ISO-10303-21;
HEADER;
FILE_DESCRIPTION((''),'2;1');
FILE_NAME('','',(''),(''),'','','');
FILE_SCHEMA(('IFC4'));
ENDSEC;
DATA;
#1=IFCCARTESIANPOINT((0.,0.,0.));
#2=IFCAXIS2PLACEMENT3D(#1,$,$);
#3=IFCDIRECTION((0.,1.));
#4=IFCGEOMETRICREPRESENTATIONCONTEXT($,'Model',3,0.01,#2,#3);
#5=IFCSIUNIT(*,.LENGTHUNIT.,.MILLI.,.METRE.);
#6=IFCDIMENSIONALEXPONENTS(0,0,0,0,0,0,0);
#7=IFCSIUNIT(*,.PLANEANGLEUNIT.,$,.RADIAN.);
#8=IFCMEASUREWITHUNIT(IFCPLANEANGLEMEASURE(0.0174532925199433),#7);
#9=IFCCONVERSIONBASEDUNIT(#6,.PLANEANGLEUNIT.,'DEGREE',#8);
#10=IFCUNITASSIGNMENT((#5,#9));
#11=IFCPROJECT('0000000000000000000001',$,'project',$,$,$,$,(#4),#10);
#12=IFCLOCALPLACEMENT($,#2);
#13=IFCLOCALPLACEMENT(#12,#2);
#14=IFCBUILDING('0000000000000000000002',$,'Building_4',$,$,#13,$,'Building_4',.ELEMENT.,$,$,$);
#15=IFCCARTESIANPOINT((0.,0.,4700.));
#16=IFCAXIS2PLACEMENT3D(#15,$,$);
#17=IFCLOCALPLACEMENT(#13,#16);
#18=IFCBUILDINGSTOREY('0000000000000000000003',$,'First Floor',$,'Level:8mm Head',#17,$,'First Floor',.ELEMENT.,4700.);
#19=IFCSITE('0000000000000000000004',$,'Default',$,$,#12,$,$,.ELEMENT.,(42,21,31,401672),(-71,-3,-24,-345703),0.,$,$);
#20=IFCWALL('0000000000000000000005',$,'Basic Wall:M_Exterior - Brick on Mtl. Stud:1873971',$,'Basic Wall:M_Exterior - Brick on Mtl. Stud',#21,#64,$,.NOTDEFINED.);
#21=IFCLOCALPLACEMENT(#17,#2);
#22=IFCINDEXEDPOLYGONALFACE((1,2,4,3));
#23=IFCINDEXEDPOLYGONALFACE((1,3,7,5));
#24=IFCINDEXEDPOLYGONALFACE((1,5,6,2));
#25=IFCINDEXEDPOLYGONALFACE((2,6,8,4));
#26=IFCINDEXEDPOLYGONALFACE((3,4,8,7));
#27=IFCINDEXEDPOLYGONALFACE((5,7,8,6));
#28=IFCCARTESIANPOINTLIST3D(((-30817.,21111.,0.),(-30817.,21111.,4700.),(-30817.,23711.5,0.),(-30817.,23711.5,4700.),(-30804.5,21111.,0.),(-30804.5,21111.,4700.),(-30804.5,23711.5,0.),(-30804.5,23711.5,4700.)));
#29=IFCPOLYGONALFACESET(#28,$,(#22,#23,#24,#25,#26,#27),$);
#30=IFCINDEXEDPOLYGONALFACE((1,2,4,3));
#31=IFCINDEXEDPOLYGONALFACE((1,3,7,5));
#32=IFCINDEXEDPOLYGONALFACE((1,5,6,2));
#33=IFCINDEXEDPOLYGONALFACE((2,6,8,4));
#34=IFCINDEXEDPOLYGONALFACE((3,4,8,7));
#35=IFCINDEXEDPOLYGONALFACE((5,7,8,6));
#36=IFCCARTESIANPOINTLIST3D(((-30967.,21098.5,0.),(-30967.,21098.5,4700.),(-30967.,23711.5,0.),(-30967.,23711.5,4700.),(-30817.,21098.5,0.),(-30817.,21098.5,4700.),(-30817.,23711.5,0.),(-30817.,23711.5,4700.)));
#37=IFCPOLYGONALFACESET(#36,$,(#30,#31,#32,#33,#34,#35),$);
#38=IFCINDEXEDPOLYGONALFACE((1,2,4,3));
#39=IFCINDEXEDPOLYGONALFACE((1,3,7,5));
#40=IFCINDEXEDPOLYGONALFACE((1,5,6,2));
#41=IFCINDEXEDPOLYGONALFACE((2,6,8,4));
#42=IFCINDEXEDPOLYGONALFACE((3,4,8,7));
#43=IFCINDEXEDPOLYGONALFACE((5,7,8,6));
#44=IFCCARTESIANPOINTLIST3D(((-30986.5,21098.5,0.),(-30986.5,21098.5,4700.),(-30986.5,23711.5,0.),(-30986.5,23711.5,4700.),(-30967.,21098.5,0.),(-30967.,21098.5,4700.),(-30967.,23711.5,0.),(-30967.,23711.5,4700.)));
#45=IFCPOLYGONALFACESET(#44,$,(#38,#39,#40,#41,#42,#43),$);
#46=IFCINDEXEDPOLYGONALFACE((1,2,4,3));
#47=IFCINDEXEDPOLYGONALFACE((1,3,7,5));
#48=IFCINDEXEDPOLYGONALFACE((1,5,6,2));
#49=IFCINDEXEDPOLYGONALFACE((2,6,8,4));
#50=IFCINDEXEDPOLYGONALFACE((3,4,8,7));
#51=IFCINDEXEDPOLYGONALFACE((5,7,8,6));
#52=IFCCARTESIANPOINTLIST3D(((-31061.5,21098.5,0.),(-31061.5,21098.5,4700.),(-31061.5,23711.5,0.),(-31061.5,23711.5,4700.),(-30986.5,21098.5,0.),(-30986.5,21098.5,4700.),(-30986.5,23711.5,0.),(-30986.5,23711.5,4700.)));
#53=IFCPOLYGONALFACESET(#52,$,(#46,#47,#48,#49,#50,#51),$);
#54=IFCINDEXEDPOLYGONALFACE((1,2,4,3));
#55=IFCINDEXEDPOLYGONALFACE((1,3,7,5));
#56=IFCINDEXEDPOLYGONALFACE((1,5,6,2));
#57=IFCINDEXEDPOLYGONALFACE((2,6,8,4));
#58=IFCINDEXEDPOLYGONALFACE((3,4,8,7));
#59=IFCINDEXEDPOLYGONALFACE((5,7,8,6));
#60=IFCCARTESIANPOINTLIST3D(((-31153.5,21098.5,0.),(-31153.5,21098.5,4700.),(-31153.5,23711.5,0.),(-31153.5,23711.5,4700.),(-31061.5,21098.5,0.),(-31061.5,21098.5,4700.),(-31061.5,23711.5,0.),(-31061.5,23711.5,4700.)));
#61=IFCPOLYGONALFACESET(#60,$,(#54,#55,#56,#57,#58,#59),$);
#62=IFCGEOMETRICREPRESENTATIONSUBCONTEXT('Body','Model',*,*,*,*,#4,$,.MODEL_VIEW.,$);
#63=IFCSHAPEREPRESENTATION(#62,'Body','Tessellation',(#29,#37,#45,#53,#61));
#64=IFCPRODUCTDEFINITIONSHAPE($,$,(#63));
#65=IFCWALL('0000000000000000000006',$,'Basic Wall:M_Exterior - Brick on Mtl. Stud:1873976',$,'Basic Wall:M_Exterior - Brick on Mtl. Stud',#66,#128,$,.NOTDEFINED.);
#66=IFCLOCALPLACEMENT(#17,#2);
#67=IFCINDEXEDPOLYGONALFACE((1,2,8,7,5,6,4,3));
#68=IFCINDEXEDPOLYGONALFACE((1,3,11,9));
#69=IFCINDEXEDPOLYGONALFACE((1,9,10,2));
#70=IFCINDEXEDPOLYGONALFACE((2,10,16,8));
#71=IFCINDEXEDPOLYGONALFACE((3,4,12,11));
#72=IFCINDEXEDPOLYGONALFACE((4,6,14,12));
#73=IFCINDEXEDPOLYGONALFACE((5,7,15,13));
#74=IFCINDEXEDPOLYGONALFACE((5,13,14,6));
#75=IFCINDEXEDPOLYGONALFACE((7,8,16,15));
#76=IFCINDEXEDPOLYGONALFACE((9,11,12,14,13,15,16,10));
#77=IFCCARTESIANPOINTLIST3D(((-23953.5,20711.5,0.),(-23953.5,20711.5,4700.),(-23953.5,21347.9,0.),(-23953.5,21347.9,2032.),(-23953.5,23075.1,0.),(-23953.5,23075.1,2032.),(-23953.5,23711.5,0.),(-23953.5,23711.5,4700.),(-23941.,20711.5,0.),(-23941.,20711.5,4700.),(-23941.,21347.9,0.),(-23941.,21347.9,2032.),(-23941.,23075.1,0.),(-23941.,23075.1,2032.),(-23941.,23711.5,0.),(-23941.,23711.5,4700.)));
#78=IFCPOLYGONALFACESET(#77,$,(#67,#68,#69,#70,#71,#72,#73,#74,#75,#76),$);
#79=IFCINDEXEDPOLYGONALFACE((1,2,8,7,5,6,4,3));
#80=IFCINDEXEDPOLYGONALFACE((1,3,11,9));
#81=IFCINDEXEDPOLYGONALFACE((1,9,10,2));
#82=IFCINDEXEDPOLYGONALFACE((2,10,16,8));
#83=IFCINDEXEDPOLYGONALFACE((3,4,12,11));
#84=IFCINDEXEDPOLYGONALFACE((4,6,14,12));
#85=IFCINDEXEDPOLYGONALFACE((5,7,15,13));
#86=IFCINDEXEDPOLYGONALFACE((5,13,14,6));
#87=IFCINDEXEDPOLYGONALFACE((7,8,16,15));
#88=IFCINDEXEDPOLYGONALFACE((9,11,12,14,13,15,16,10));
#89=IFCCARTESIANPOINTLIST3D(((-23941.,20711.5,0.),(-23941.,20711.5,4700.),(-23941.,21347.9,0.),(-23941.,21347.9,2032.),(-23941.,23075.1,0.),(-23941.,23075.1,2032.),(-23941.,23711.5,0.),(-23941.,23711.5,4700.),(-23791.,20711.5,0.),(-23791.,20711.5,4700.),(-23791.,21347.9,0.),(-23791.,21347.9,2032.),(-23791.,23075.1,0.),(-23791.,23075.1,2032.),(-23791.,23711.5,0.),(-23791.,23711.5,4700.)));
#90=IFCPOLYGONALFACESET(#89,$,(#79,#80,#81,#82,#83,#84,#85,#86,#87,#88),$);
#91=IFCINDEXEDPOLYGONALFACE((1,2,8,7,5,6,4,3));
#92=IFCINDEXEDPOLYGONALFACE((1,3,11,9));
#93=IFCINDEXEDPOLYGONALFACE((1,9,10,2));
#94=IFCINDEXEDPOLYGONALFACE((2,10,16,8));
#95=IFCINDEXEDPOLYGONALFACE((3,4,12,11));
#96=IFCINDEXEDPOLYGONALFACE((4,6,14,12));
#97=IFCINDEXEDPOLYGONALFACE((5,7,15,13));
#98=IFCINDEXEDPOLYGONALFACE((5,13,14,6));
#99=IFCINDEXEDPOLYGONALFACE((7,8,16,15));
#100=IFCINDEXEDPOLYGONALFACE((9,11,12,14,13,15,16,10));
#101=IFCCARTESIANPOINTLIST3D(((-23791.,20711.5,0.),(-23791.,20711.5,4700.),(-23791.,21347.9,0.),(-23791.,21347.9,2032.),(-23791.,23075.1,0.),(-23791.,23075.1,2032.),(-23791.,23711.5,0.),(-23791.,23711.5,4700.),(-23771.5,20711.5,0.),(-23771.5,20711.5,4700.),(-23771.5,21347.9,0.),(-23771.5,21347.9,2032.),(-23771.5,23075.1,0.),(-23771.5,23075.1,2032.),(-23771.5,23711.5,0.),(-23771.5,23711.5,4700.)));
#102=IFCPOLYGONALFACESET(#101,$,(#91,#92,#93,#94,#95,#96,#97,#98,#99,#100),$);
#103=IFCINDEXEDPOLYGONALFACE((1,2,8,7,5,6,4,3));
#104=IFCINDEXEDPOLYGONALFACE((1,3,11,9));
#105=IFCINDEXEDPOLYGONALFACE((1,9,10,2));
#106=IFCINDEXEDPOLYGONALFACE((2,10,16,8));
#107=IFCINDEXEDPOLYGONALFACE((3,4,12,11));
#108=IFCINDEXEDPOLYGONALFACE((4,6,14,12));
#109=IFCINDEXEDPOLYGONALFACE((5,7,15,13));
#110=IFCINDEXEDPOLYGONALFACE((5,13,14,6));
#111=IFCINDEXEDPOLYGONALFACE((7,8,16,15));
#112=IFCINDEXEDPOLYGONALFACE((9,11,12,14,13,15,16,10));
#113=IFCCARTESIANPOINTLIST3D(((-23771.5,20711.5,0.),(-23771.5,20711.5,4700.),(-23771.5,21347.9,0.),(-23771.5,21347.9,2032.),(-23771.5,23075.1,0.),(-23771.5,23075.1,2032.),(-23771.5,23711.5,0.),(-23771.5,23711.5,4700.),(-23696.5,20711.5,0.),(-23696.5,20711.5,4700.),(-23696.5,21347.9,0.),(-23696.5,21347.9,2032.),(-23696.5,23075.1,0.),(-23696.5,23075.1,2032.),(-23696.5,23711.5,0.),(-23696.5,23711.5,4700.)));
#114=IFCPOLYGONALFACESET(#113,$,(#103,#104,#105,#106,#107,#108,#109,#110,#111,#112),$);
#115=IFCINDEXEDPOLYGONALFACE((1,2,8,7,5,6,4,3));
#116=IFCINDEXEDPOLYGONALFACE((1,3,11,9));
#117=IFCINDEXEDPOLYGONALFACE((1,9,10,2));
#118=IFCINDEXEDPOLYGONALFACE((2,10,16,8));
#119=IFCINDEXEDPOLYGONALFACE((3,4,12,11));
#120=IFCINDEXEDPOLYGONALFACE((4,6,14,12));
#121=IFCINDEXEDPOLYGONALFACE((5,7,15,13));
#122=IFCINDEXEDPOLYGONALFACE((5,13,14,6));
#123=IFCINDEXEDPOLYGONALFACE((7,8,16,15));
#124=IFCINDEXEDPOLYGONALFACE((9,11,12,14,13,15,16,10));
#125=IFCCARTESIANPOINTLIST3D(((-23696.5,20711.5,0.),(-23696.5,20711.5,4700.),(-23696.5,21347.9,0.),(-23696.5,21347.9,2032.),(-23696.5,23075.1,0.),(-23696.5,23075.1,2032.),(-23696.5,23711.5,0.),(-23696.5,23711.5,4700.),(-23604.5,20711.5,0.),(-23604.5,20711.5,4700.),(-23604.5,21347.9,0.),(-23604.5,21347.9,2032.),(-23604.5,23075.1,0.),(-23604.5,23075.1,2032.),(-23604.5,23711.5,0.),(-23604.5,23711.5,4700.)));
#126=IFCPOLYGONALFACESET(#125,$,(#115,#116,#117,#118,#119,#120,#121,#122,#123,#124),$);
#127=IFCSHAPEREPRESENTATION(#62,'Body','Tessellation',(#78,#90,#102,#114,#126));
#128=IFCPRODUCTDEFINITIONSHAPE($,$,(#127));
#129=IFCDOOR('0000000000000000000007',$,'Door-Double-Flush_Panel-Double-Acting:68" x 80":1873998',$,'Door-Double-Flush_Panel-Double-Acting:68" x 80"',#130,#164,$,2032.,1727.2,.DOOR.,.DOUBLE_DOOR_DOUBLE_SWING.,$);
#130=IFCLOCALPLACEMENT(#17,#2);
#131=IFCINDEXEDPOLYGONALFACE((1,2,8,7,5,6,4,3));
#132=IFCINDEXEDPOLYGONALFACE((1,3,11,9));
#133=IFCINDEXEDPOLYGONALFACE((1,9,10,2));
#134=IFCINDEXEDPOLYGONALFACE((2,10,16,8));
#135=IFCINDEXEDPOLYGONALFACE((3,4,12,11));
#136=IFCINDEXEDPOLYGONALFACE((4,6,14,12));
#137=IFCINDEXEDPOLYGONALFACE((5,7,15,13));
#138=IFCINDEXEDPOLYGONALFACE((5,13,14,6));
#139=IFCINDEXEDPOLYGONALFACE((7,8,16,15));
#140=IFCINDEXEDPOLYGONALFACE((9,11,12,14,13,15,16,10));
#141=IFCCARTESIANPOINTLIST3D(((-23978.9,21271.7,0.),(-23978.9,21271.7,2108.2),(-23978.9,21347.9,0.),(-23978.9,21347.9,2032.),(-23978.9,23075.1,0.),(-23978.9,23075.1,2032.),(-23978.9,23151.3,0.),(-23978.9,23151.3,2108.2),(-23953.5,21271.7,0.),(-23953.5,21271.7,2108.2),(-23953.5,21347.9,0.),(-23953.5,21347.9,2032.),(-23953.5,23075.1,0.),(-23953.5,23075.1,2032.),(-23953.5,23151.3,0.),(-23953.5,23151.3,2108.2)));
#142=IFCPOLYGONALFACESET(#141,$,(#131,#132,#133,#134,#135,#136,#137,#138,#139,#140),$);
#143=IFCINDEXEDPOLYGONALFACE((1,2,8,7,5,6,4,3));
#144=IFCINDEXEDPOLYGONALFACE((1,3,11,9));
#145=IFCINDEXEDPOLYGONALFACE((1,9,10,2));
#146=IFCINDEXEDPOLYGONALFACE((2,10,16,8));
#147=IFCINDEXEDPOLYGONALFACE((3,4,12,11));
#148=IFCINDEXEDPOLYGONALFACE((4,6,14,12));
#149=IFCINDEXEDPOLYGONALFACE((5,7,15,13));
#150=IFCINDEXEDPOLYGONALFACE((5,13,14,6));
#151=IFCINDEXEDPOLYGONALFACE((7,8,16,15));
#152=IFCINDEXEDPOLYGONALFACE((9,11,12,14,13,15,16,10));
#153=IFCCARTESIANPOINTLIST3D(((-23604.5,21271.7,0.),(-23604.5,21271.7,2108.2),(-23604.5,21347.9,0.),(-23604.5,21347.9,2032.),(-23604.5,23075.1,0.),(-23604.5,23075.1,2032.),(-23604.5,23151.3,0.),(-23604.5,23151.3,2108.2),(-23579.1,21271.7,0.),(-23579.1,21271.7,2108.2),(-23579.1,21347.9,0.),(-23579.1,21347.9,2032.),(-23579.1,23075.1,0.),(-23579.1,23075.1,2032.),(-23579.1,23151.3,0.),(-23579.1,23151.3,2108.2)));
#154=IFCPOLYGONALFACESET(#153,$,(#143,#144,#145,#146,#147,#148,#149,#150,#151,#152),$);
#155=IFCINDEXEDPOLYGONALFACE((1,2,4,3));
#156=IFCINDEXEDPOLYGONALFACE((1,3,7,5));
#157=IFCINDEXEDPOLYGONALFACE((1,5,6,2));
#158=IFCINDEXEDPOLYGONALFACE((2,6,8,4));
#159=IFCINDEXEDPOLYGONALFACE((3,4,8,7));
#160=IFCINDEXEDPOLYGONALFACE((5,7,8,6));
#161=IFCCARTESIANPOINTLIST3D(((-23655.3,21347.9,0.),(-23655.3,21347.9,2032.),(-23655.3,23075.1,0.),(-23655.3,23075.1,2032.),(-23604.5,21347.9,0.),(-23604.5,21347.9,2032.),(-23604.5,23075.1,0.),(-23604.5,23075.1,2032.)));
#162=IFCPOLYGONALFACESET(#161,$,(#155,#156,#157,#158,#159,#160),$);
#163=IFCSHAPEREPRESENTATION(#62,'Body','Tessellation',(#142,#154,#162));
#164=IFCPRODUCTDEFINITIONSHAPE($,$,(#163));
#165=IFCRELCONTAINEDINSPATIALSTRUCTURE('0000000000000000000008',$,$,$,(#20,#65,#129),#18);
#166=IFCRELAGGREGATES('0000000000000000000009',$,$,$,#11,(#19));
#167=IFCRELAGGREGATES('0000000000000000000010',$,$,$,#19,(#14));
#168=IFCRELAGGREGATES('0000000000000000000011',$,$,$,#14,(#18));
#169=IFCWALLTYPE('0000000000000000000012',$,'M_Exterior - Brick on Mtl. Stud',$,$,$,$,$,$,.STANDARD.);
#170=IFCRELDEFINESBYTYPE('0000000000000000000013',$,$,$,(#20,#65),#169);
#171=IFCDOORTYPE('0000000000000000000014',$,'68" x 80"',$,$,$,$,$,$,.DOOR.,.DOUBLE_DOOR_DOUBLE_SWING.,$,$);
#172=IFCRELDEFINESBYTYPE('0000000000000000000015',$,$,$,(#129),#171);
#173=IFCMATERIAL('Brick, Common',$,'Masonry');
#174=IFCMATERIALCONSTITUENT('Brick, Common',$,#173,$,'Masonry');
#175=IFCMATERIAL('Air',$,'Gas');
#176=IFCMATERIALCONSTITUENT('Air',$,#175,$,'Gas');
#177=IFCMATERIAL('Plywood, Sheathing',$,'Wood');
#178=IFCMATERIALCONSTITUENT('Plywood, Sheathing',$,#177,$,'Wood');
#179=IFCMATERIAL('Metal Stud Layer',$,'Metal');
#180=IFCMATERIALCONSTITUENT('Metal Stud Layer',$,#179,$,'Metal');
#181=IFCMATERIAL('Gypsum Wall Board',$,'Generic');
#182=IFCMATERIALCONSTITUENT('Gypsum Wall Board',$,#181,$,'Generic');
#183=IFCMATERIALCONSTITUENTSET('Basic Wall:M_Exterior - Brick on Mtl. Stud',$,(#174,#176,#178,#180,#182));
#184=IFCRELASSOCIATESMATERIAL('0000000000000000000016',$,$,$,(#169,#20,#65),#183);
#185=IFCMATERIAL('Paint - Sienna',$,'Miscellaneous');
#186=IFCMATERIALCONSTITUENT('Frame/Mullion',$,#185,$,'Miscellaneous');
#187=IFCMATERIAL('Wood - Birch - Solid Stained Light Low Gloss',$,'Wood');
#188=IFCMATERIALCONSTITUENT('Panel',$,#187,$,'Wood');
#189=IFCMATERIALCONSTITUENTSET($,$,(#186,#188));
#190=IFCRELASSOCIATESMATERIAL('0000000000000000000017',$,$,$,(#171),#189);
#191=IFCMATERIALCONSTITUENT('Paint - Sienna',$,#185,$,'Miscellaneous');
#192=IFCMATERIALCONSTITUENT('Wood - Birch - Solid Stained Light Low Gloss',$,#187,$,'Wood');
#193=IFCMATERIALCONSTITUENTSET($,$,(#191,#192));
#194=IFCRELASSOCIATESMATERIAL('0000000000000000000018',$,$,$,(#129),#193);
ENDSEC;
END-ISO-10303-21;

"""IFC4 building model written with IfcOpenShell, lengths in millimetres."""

from ifc_helpers import new_model, entity, si_unit, converted_unit, direction, frame, origin, place, context, subcontext, project, spatial, indexed_curve, outline, extrude, source, transform, mapped, material, constituent, constituent_set, type_object, type_shapes, element, fill, save


model = new_model("IFC4")

# Units and contexts
model_context = context("Model", 3, precision=0.01, world=origin(), true_north=direction((0.0, 1.0)))
body_context = subcontext(model_context, "Body", "Model", "MODEL_VIEW")
ifc_project = project(units=[si_unit("LENGTHUNIT", "METRE", prefix="MILLI"), converted_unit("PLANEANGLEUNIT", "DEGREE", entity("IfcPlaneAngleMeasure", 0.0174532925199433), si_unit("PLANEANGLEUNIT", "RADIAN"), dimensions=[0, 0, 0, 0, 0, 0, 0])], contexts=[model_context])

# Site, building, storey
site_placement = place(None, origin())
site = spatial("IfcSite", under=ifc_project, at=site_placement, Name="Default", CompositionType="ELEMENT", RefLatitude=(42, 21, 31, 401672), RefLongitude=(-71, -3, -24, -345703), RefElevation=0.0)
building_placement = place(site_placement, origin())
building = spatial("IfcBuilding", under=site, at=building_placement, Name="Building_4", LongName="Building_4", CompositionType="ELEMENT")
storey_placement = place(building_placement, frame((0.0, 0.0, 4700.0)))
storey = spatial("IfcBuildingStorey", under=building, at=storey_placement, Name="First Floor", ObjectType="Level:8mm Head", LongName="First Floor", CompositionType="ELEMENT", Elevation=4700.0)

# Shared definitions
ifc_material_1 = material(Name="Brick, Common", Category="Masonry")
ifc_constituent_1 = constituent(ifc_material_1, Name="Brick, Common", Category="Masonry")
ifc_material_2 = material(Name="Air", Category="Gas")
ifc_constituent_2 = constituent(ifc_material_2, Name="Air", Category="Gas")
ifc_material_3 = material(Name="Plywood, Sheathing", Category="Wood")
ifc_constituent_3 = constituent(ifc_material_3, Name="Plywood, Sheathing", Category="Wood")
ifc_material_4 = material(Name="Metal Stud Layer", Category="Metal")
ifc_constituent_4 = constituent(ifc_material_4, Name="Metal Stud Layer", Category="Metal")
ifc_material_5 = material(Name="Gypsum Wall Board", Category="Generic")
ifc_constituent_5 = constituent(ifc_material_5, Name="Gypsum Wall Board", Category="Generic")
ifc_constituent_set_1 = constituent_set(constituents=[ifc_constituent_1, ifc_constituent_2, ifc_constituent_3, ifc_constituent_4, ifc_constituent_5], Name="Basic Wall:M_Exterior - Brick on Mtl. Stud")
wall_type_1 = type_object("IfcWallType", Name="M_Exterior - Brick on Mtl. Stud", PredefinedType="STANDARD", material=ifc_constituent_set_1)

# Wall
wall_1_placement = place(storey_placement, frame((-30979.0, 21111.0, 0.0), z_axis=(0.0, 0.0, 1.0), x_axis=(0.0, 1.0, 0.0)))
element("IfcWall", 1, at=wall_1_placement, inside=storey, type_object=wall_type_1, material=ifc_constituent_set_1, Name="Basic Wall:M_Exterior - Brick on Mtl. Stud:1873971", ObjectType="Basic Wall:M_Exterior - Brick on Mtl. Stud", PredefinedType="NOTDEFINED", context=body_context, shape_type="SweptSolid", body=[
    extrude(outline(indexed_curve([(-6.3, -1300.2), (6.2, -1300.2), (6.2, 1300.2), (-6.2, 1300.2), (-6.3, -1300.2)], self_intersect=False)), frame((1300.2, -168.2, 0.0), z_axis=(0.0, 0.0, 1.0), x_axis=(0.0, 1.0, 0.0)), (0.0, 0.0, 1.0), 4700.0),
    extrude(outline(indexed_curve([(-1306.5, -75.0), (1306.5, -75.0), (1306.5, 75.0), (-1306.5, 75.0), (-1306.5, -75.0)], self_intersect=False)), frame((1294.0, -87.0, 0.0)), (0.0, 0.0, 1.0), 4700.0),
    extrude(outline(indexed_curve([(-1306.5, -9.7), (1306.5, -9.7), (1306.5, 9.7), (-1306.5, 9.7), (-1306.5, -9.7)], self_intersect=False)), frame((1294.0, -2.3, 0.0)), (0.0, 0.0, 1.0), 4700.0),
    extrude(outline(indexed_curve([(-1306.5, -37.5), (1306.5, -37.5), (1306.5, 37.5), (-1306.5, 37.5), (-1306.5, -37.5)], self_intersect=False)), frame((1294.0, 45.0, 0.0)), (0.0, 0.0, 1.0), 4700.0),
    extrude(outline(indexed_curve([(-46.0, -1306.5), (46.0, -1306.5), (46.0, 1306.5), (-46.0, 1306.5), (-46.0, -1306.5)], self_intersect=False)), frame((1294.0, 128.5, 0.0), z_axis=(0.0, 0.0, 1.0), x_axis=(0.0, -1.0, 0.0)), (0.0, 0.0, 1.0), 4700.0),
])

# Wall, opening, door
wall_2_placement = place(storey_placement, frame((-23779.0, 23711.5, 0.0), z_axis=(0.0, 0.0, 1.0), x_axis=(0.0, -1.0, 0.0)))
wall_2 = element("IfcWall", 2, at=wall_2_placement, inside=storey, type_object=wall_type_1, material=ifc_constituent_set_1, Name="Basic Wall:M_Exterior - Brick on Mtl. Stud:1873976", ObjectType="Basic Wall:M_Exterior - Brick on Mtl. Stud", PredefinedType="NOTDEFINED", context=body_context, shape_type="SweptSolid", body=[
    extrude(outline(indexed_curve([(-1500.0, -1683.0), (-863.6, -1683.0), (-863.6, 349.0), (863.6, 349.0), (863.6, -1683.0), (1500.0, -1683.0), (1500.0, 3017.0), (-1500.0, 3017.0), (-1500.0, -1683.0)], self_intersect=False)), frame((1500.0, -174.5, 1683.0), z_axis=(0.0, 1.0, 0.0), x_axis=(-1.0, 0.0, 0.0)), (0.0, 0.0, 1.0), 12.5),
    extrude(outline(indexed_curve([(-1683.0, -863.6), (-1683.0, -1500.0), (3017.0, -1500.0), (3017.0, 1500.0), (-1683.0, 1500.0), (-1683.0, 863.6), (349.0, 863.6), (349.0, -863.6), (-1683.0, -863.6)], self_intersect=False)), frame((1500.0, -162.0, 1683.0), z_axis=(0.0, -1.0, 0.0), x_axis=(0.0, 0.0, 1.0)), (0.0, 0.0, -1.0), 150.0),
    extrude(outline(indexed_curve([(-1683.0, -863.6), (-1683.0, -1500.0), (3017.0, -1500.0), (3017.0, 1500.0), (-1683.0, 1500.0), (-1683.0, 863.6), (349.0, 863.6), (349.0, -863.6), (-1683.0, -863.6)], self_intersect=False)), frame((1500.0, -12.0, 1683.0), z_axis=(0.0, -1.0, 0.0), x_axis=(0.0, 0.0, 1.0)), (0.0, 0.0, -1.0), 19.5),
    extrude(outline(indexed_curve([(-1683.0, -863.6), (-1683.0, -1500.0), (3017.0, -1500.0), (3017.0, 1500.0), (-1683.0, 1500.0), (-1683.0, 863.6), (349.0, 863.6), (349.0, -863.6), (-1683.0, -863.6)], self_intersect=False)), frame((1500.0, 7.5, 1683.0), z_axis=(0.0, -1.0, 0.0), x_axis=(0.0, 0.0, 1.0)), (0.0, 0.0, -1.0), 75.0),
    extrude(outline(indexed_curve([(-1683.0, -863.6), (-1683.0, -1500.0), (3017.0, -1500.0), (3017.0, 1500.0), (-1683.0, 1500.0), (-1683.0, 863.6), (349.0, 863.6), (349.0, -863.6), (-1683.0, -863.6)], self_intersect=False)), frame((1500.0, 82.5, 1683.0), z_axis=(0.0, -1.0, 0.0), x_axis=(0.0, 0.0, 1.0)), (0.0, 0.0, -1.0), 92.0),
])
opening_1_placement = place(wall_2_placement, frame((636.4, -174.5, 0.0)))
opening_1 = element("IfcOpeningElement", 3, at=opening_1_placement, cuts=wall_2, PredefinedType="OPENING", context=body_context, shape_type="SweptSolid", body=[
    extrude(outline(indexed_curve([(0.0, 1727.2), (0.0, 0.0), (2032.0, 0.0), (2032.0, 1727.2), (0.0, 1727.2)], self_intersect=False)), frame((0.0, 0.0, 0.0), z_axis=(0.0, 1.0, 0.0), x_axis=(0.0, 0.0, 1.0)), (0.0, 0.0, 1.0), 349.0),
])
ifc_material_6 = material(Name="Paint - Sienna", Category="Miscellaneous")
ifc_constituent_6 = constituent(ifc_material_6, Name="Paint - Sienna", Category="Miscellaneous")
ifc_material_7 = material(Name="Wood - Birch - Solid Stained Light Low Gloss", Category="Wood")
ifc_constituent_7 = constituent(ifc_material_7, Name="Wood - Birch - Solid Stained Light Low Gloss", Category="Wood")
ifc_constituent_set_2 = constituent_set(constituents=[ifc_constituent_6, ifc_constituent_7])
ifc_constituent_8 = constituent(ifc_material_6, Name="Frame/Mullion", Category="Miscellaneous")
ifc_constituent_9 = constituent(ifc_material_7, Name="Panel", Category="Wood")
ifc_constituent_set_3 = constituent_set(constituents=[ifc_constituent_8, ifc_constituent_9])
door_type = type_object("IfcDoorType", Name="68\" x 80\"", OperationType="DOUBLE_DOOR_DOUBLE_SWING", PredefinedType="DOOR", material=ifc_constituent_set_3)
shared_shape_1 = source(origin(), body_context, "Body", "SweptSolid", [
    extrude(outline(indexed_curve([(-997.0, 863.6), (1035.0, 863.6), (1035.0, 939.8), (-1073.2, 939.8), (-1073.2, -939.8), (1035.0, -939.8), (1035.0, -863.6), (-997.0, -863.6), (-997.0, 863.6)], self_intersect=False)), frame((863.6, -25.4, 1035.0), z_axis=(0.0, 1.0, 0.0), x_axis=(0.0, 0.0, -1.0)), (0.0, 0.0, 1.0), 25.4),
    extrude(outline(indexed_curve([(-939.8, -1073.2), (939.8, -1073.2), (939.8, 1035.0), (863.6, 1035.0), (863.6, -997.0), (-863.6, -997.0), (-863.6, 1035.0), (-939.8, 1035.0), (-939.8, -1073.2)], self_intersect=False)), frame((863.6, 349.0, 1035.0), z_axis=(0.0, 1.0, 0.0), x_axis=(1.0, 0.0, 0.0)), (0.0, 0.0, 1.0), 25.4),
    extrude(outline(indexed_curve([(-25.4, -863.6), (25.4, -863.6), (25.4, 863.6), (-25.4, 863.6), (-25.4, -863.6)], self_intersect=False)), frame((863.6, 323.6, 0.0), z_axis=(0.0, 0.0, 1.0), x_axis=(0.0, -1.0, 0.0)), (0.0, 0.0, 1.0), 2032.0),
])
type_shapes(door_type, [shared_shape_1])
door_placement = place(opening_1_placement, origin())
door = element("IfcDoor", 4, at=door_placement, inside=storey, type_object=door_type, material=ifc_constituent_set_2, Name="Door-Double-Flush_Panel-Double-Acting:68\" x 80\":1873998", ObjectType="Door-Double-Flush_Panel-Double-Acting:68\" x 80\"", OperationType="DOUBLE_DOOR_DOUBLE_SWING", OverallHeight=2032.0, OverallWidth=1727.2, PredefinedType="DOOR", context=body_context, shape_type="MappedRepresentation", body=[
    mapped(shared_shape_1, transform((0.0, 0.0, 0.0), scale=1.0)),
])
fill(opening_1, door)

save(model, "model.ifc")
